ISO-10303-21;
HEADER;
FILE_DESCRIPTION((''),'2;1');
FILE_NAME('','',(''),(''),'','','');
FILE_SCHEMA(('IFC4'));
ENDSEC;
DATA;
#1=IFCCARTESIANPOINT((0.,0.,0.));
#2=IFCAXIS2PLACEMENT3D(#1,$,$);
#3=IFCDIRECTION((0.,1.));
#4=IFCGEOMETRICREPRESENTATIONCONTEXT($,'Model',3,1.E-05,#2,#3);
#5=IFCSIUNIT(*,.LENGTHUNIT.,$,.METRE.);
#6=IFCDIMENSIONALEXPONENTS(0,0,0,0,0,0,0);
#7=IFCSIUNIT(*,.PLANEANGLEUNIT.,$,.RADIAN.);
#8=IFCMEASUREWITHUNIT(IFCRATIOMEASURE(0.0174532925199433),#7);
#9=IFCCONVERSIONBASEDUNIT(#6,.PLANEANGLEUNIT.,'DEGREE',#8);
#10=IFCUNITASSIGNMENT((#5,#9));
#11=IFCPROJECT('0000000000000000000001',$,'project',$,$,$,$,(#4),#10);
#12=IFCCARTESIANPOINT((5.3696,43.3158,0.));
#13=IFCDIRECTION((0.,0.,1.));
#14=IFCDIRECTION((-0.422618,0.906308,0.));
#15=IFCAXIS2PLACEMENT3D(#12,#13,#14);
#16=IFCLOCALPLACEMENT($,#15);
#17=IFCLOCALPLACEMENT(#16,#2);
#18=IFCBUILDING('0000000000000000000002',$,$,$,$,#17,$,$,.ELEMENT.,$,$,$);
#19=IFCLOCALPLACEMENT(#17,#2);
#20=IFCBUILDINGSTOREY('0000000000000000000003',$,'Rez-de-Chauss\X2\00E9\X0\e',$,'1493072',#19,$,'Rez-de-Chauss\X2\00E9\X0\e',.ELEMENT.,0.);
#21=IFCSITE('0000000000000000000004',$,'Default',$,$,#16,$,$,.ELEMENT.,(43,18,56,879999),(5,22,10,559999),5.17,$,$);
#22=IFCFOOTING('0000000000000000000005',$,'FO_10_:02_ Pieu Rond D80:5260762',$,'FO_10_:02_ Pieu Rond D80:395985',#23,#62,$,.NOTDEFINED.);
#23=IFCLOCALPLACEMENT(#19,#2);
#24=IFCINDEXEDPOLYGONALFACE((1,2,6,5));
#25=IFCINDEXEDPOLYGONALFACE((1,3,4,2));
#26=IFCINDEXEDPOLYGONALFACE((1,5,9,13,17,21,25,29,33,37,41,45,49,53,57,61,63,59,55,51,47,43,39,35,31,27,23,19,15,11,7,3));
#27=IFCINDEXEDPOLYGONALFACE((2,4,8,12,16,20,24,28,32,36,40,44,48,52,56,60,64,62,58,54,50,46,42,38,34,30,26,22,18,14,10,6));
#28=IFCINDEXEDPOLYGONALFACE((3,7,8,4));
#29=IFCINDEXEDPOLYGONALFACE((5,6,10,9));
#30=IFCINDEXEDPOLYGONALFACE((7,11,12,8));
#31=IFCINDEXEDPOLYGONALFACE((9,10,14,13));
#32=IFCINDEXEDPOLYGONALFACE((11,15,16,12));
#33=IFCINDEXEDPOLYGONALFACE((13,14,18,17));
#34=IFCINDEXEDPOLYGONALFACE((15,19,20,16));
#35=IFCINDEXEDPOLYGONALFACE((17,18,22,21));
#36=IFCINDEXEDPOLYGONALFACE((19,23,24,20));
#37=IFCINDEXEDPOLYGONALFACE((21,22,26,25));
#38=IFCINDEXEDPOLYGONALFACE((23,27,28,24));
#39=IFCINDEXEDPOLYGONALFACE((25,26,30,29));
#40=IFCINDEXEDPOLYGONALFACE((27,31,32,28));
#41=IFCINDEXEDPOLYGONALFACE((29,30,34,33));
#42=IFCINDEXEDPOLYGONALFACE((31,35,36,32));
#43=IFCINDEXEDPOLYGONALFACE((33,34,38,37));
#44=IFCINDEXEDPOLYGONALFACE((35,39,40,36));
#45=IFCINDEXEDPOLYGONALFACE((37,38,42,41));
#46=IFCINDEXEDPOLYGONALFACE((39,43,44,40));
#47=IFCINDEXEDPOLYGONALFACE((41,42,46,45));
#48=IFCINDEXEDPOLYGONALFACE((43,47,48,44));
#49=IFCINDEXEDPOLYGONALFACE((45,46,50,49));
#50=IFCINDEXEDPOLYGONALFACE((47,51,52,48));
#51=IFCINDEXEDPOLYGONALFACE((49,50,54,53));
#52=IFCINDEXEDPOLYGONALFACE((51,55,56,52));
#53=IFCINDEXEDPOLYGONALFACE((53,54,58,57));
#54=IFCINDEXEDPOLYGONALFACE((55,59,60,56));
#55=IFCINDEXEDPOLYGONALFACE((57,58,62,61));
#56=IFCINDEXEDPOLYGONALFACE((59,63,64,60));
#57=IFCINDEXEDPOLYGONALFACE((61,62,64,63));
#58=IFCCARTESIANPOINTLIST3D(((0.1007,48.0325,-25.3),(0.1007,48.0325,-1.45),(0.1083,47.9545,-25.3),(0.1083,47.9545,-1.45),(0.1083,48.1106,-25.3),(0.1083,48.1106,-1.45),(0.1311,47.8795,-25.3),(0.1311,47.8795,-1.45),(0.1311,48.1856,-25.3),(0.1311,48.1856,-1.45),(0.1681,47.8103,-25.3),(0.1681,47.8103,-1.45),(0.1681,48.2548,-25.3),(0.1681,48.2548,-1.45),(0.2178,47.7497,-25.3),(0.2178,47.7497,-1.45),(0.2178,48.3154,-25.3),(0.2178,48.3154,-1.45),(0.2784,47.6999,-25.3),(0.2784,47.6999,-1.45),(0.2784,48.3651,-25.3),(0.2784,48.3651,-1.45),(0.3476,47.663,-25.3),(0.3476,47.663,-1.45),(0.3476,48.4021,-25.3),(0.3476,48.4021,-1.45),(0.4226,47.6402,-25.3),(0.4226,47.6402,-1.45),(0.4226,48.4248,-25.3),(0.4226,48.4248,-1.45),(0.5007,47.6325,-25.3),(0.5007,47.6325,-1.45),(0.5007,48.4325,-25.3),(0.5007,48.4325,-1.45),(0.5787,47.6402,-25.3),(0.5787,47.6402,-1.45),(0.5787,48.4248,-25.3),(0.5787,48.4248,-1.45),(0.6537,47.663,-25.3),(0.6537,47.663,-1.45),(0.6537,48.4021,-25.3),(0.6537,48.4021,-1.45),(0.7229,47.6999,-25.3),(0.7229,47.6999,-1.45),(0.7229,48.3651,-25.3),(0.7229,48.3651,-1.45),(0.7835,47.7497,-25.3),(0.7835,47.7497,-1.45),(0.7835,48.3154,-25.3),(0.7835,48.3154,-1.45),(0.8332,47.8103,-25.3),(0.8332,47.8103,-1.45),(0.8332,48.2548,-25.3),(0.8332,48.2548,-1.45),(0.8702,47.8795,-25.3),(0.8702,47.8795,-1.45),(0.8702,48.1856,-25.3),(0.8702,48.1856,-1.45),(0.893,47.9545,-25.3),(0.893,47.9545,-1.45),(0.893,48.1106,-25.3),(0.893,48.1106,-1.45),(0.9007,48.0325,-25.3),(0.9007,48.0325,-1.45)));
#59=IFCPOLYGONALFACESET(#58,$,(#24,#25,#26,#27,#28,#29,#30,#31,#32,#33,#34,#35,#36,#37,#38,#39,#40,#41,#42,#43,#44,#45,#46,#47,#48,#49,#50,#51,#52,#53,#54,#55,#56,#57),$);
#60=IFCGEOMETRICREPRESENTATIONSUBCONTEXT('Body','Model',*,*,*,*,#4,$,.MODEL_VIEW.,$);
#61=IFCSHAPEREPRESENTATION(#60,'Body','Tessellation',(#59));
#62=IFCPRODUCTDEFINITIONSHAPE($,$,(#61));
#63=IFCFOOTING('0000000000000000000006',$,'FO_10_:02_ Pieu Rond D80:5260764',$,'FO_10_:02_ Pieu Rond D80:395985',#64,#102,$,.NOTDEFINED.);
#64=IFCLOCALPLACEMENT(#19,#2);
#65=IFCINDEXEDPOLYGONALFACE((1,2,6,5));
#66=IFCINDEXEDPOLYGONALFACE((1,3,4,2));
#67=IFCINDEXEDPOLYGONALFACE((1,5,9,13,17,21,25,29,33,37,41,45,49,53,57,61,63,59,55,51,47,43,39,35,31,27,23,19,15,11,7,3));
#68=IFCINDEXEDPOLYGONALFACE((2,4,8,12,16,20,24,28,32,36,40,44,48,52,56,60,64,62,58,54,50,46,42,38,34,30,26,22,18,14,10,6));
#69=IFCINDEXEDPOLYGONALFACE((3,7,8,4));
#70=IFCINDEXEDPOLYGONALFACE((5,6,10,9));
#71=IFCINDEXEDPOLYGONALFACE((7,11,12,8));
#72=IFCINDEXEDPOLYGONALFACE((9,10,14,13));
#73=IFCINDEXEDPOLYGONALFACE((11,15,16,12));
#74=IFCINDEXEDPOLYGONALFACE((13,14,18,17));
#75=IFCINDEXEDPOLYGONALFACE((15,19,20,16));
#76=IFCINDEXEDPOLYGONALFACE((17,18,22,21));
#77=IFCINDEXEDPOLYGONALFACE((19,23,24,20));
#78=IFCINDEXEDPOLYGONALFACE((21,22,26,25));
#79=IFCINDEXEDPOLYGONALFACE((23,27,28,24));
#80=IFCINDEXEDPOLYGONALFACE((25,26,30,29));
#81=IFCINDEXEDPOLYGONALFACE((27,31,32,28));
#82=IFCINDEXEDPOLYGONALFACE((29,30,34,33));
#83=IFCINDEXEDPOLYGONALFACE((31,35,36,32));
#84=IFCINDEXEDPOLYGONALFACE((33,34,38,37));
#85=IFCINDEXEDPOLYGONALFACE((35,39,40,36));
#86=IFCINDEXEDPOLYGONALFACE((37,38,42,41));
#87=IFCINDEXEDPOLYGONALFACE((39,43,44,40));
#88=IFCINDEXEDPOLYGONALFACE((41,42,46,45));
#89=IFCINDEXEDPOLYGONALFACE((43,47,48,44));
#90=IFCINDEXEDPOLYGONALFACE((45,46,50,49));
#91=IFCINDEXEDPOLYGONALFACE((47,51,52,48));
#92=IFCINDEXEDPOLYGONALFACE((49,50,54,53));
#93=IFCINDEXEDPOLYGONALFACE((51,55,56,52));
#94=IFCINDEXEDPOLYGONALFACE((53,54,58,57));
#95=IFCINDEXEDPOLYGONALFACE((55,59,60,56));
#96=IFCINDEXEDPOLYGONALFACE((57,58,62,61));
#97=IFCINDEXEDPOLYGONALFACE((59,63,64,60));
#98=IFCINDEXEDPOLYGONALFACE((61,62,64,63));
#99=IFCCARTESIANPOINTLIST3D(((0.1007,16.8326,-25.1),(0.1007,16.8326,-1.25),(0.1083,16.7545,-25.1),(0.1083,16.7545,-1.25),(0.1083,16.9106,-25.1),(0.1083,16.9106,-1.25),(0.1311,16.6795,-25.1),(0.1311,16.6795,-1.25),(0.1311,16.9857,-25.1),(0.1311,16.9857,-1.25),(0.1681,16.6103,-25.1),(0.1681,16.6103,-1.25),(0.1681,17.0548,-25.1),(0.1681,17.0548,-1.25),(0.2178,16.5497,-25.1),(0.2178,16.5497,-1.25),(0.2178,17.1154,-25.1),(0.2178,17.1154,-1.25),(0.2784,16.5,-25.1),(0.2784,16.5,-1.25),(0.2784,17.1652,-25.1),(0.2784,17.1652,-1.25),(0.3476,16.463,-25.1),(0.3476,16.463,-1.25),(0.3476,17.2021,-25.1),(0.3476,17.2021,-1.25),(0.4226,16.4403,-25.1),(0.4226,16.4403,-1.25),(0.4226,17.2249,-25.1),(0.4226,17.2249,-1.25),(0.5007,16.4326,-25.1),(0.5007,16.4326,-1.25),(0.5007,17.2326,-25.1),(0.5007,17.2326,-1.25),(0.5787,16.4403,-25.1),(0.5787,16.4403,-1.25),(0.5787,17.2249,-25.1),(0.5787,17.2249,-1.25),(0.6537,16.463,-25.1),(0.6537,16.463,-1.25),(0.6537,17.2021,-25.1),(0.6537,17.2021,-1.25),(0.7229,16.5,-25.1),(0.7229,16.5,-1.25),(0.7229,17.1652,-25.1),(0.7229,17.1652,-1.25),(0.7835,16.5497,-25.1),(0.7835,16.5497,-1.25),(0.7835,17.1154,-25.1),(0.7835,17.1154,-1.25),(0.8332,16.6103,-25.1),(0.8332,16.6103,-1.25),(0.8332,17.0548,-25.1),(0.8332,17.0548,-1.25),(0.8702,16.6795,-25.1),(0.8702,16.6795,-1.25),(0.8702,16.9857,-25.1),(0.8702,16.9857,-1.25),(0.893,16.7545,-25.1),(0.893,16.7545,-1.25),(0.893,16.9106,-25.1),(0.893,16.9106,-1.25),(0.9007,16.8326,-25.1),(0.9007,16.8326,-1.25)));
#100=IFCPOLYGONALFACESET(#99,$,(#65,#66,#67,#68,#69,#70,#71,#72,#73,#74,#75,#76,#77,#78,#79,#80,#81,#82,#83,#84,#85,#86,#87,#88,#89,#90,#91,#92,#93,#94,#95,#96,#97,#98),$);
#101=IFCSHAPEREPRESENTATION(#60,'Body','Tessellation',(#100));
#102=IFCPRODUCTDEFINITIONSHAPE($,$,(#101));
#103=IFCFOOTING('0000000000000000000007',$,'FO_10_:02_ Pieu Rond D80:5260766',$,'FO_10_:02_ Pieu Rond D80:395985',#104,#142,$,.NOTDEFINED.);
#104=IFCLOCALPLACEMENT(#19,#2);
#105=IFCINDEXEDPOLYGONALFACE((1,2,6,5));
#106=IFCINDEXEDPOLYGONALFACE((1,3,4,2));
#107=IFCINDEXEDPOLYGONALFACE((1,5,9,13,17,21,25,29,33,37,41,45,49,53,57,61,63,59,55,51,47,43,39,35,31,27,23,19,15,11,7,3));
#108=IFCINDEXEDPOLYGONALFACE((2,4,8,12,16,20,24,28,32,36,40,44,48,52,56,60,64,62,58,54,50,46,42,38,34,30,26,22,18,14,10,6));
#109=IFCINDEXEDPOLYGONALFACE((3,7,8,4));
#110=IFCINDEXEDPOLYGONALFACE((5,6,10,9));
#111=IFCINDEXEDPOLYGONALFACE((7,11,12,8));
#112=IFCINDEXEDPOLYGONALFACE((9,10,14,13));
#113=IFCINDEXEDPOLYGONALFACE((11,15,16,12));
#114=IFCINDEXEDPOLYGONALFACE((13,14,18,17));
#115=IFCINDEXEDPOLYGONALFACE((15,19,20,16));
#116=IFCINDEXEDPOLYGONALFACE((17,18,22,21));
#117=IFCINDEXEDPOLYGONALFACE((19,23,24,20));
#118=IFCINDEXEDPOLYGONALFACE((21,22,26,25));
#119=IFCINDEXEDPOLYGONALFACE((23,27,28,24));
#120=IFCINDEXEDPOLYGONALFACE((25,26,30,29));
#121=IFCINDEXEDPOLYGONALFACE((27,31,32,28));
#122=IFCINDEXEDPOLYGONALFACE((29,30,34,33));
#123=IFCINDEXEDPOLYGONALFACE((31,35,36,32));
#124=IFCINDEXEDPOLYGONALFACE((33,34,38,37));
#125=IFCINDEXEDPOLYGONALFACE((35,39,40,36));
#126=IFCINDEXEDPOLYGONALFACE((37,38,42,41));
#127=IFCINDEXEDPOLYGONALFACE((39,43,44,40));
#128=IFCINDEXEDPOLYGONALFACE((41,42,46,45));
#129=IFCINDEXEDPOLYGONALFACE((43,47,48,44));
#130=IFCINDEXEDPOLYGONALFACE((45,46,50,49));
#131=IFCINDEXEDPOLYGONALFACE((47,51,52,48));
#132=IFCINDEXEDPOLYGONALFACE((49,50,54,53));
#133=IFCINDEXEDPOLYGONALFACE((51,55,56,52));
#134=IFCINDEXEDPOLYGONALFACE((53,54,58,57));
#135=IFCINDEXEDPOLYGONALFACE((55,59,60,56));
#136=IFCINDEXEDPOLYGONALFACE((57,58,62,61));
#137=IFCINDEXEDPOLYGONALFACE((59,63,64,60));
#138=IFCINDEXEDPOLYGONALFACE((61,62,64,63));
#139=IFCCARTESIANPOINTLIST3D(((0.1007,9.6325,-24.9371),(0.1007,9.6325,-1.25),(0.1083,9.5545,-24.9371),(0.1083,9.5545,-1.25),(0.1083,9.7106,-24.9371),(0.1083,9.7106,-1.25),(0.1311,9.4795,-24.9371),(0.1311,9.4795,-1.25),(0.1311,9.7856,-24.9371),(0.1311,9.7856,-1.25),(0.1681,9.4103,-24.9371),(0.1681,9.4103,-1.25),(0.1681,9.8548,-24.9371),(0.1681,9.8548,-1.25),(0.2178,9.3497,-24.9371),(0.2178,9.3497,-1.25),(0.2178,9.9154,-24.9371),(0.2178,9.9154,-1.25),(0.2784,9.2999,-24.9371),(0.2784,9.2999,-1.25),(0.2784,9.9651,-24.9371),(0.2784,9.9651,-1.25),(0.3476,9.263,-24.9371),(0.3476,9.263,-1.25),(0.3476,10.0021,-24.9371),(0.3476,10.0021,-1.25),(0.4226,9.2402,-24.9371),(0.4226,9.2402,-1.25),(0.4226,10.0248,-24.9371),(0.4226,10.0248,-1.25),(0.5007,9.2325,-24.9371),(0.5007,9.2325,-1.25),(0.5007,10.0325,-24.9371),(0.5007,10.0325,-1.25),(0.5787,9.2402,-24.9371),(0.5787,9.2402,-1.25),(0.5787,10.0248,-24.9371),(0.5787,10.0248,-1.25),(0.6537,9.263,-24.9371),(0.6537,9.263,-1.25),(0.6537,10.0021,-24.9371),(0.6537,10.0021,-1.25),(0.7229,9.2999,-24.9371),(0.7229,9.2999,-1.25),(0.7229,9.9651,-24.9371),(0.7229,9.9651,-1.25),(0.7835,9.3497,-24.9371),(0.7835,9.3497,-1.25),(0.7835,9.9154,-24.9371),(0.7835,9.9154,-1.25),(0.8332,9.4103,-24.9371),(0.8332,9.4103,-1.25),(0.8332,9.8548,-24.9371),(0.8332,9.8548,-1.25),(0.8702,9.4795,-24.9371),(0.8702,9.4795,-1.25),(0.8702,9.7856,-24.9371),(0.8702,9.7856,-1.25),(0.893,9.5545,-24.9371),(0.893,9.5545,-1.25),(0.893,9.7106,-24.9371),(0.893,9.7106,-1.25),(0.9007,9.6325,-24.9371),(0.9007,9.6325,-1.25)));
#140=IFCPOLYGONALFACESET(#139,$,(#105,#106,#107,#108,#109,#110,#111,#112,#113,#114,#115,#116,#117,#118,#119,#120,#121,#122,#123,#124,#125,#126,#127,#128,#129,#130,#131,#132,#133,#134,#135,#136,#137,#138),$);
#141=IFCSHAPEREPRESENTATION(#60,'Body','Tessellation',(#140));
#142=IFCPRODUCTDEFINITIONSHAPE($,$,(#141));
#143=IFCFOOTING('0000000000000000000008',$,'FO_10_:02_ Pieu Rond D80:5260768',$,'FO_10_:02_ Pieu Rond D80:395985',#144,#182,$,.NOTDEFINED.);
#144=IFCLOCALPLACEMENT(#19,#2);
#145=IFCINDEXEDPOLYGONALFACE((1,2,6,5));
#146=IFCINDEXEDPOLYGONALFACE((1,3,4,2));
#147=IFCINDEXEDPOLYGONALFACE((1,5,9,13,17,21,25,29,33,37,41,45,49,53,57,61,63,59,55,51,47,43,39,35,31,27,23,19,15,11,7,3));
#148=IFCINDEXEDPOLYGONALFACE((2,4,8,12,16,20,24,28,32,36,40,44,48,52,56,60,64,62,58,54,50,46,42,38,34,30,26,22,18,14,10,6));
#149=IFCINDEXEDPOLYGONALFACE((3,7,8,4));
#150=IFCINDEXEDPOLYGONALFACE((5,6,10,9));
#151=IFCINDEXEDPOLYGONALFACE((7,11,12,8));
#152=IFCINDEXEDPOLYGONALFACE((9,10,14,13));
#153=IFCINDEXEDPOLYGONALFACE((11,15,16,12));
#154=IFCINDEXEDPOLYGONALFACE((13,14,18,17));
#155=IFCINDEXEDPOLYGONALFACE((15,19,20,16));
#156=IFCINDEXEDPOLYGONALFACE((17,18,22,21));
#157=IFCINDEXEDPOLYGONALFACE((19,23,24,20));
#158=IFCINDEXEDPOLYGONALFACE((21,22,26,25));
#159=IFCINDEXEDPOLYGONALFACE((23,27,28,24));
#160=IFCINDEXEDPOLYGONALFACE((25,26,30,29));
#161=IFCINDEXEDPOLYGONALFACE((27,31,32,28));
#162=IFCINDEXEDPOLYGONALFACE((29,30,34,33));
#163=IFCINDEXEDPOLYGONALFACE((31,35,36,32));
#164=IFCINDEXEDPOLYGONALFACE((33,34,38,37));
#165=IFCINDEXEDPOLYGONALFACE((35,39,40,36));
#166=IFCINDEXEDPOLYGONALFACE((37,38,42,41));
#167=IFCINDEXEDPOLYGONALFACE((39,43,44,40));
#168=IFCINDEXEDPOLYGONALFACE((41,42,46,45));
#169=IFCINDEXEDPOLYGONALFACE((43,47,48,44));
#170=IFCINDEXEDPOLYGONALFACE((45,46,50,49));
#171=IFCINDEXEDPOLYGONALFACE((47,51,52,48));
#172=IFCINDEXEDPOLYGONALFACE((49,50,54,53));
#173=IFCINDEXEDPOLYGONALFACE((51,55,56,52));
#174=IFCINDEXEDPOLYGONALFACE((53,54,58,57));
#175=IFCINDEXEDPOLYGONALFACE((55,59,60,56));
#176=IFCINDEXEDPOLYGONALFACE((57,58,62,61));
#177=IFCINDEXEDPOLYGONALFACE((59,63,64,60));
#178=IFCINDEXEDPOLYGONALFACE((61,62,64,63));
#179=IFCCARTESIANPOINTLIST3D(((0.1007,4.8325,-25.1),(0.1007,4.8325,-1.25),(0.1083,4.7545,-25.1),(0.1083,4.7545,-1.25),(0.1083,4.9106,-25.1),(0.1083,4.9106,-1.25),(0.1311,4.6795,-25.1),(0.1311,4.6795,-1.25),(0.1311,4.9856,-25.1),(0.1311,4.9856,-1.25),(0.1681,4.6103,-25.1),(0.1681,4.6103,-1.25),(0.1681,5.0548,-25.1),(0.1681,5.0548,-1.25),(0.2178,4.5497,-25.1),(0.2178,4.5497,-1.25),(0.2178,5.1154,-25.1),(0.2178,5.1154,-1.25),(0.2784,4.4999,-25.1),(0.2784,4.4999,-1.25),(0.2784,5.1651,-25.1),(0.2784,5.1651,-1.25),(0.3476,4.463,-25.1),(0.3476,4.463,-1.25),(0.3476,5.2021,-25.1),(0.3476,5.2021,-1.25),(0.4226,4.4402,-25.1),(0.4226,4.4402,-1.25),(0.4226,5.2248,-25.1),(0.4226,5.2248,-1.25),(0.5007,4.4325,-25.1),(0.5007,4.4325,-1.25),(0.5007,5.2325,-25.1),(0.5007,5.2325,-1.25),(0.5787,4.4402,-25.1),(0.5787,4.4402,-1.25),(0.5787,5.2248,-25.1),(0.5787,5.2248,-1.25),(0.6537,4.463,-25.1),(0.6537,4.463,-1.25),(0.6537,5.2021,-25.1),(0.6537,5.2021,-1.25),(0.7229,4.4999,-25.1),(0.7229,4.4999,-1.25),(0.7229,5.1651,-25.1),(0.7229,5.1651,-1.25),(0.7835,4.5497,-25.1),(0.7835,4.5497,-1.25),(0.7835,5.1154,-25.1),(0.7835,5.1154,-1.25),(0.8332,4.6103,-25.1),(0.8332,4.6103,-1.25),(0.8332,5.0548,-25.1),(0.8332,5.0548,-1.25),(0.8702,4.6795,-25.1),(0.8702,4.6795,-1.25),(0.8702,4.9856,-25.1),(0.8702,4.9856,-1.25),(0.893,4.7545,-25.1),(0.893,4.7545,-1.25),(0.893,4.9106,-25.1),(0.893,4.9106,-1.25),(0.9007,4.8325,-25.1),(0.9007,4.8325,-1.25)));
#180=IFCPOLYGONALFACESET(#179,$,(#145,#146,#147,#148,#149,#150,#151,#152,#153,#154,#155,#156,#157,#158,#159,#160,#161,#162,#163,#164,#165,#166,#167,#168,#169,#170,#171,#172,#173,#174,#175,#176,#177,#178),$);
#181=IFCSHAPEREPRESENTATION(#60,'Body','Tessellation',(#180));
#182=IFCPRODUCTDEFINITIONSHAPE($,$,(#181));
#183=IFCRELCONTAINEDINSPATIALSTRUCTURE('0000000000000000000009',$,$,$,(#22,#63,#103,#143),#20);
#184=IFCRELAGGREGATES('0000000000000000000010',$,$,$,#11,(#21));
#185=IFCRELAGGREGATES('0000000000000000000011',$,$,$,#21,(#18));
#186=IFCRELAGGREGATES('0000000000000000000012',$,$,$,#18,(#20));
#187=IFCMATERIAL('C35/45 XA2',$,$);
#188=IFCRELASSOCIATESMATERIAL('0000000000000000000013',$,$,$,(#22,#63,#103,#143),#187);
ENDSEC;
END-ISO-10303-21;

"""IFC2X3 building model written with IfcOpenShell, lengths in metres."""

from ifc_helpers import new_model, entity, si_unit, converted_unit, direction, frame, frame_2d, origin, place, context, subcontext, project, spatial, circle, extrude, material, element, save


model = new_model("IFC2X3")

# Units and contexts
model_context = context("Model", 3, precision=1e-05, world=origin(), true_north=direction((0.0, 1.0)))
body_context = subcontext(model_context, "Body", "Model", "MODEL_VIEW")
ifc_project = project(units=[si_unit("LENGTHUNIT", "METRE"), converted_unit("PLANEANGLEUNIT", "DEGREE", entity("IfcRatioMeasure", 0.0174532925199433), si_unit("PLANEANGLEUNIT", "RADIAN"), dimensions=[0, 0, 0, 0, 0, 0, 0])], contexts=[model_context])

# Site, building, storey
site_placement = place(None, frame((5.3696, 43.3158, 0.0), z_axis=(0.0, 0.0, 1.0), x_axis=(-0.422618, 0.906308, 0.0)))
site = spatial("IfcSite", under=ifc_project, at=site_placement, Name="Default", CompositionType="ELEMENT", RefLatitude=(43, 18, 56, 879999), RefLongitude=(5, 22, 10, 559999), RefElevation=5.17)
building_placement = place(site_placement, origin())
building = spatial("IfcBuilding", under=site, at=building_placement, CompositionType="ELEMENT")
storey_placement = place(building_placement, origin())
storey = spatial("IfcBuildingStorey", under=building, at=storey_placement, Name="Rez-de-Chaussée", ObjectType="1493072", LongName="Rez-de-Chaussée", CompositionType="ELEMENT", Elevation=0.0)

# Footings
ifc_material_1 = material(Name="C35/45 XA2")
footing_1_placement = place(storey_placement, origin())
element("IfcFooting", 1, at=footing_1_placement, inside=storey, material=ifc_material_1, Name="FO_10_:02_ Pieu Rond D80:5260762", ObjectType="FO_10_:02_ Pieu Rond D80:395985", PredefinedType="NOTDEFINED", context=body_context, shape_type="SweptSolid", body=[
    extrude(circle(Radius=0.4, at=frame_2d((0.0, 0.0), x_axis=(1.0, 0.0))), frame((0.5007, 48.0325, -25.3), z_axis=(0.0, 0.0, 1.0), x_axis=(0.0, -1.0, 0.0)), (0.0, 0.0, 1.0), 23.85),
])
footing_2_placement = place(storey_placement, origin())
element("IfcFooting", 2, at=footing_2_placement, inside=storey, material=ifc_material_1, Name="FO_10_:02_ Pieu Rond D80:5260764", ObjectType="FO_10_:02_ Pieu Rond D80:395985", PredefinedType="NOTDEFINED", context=body_context, shape_type="SweptSolid", body=[
    extrude(circle(Radius=0.4, at=frame_2d((0.0, 0.0), x_axis=(1.0, 0.0))), frame((0.5007, 16.8326, -25.1), z_axis=(0.0, 0.0, 1.0), x_axis=(0.0, -1.0, 0.0)), (0.0, 0.0, 1.0), 23.85),
])
footing_3_placement = place(storey_placement, origin())
element("IfcFooting", 3, at=footing_3_placement, inside=storey, material=ifc_material_1, Name="FO_10_:02_ Pieu Rond D80:5260766", ObjectType="FO_10_:02_ Pieu Rond D80:395985", PredefinedType="NOTDEFINED", context=body_context, shape_type="SweptSolid", body=[
    extrude(circle(Radius=0.4, at=frame_2d((0.0, 0.0), x_axis=(1.0, 0.0))), frame((0.5007, 9.6325, -24.9371), z_axis=(0.0, 0.0, 1.0), x_axis=(0.0, -1.0, 0.0)), (0.0, 0.0, 1.0), 23.6871),
])
footing_4_placement = place(storey_placement, origin())
element("IfcFooting", 4, at=footing_4_placement, inside=storey, material=ifc_material_1, Name="FO_10_:02_ Pieu Rond D80:5260768", ObjectType="FO_10_:02_ Pieu Rond D80:395985", PredefinedType="NOTDEFINED", context=body_context, shape_type="SweptSolid", body=[
    extrude(circle(Radius=0.4, at=frame_2d((0.0, 0.0), x_axis=(1.0, 0.0))), frame((0.5007, 4.8325, -25.1), z_axis=(0.0, 0.0, 1.0), x_axis=(0.0, -1.0, 0.0)), (0.0, 0.0, 1.0), 23.85),
])

save(model, "model.ifc")
